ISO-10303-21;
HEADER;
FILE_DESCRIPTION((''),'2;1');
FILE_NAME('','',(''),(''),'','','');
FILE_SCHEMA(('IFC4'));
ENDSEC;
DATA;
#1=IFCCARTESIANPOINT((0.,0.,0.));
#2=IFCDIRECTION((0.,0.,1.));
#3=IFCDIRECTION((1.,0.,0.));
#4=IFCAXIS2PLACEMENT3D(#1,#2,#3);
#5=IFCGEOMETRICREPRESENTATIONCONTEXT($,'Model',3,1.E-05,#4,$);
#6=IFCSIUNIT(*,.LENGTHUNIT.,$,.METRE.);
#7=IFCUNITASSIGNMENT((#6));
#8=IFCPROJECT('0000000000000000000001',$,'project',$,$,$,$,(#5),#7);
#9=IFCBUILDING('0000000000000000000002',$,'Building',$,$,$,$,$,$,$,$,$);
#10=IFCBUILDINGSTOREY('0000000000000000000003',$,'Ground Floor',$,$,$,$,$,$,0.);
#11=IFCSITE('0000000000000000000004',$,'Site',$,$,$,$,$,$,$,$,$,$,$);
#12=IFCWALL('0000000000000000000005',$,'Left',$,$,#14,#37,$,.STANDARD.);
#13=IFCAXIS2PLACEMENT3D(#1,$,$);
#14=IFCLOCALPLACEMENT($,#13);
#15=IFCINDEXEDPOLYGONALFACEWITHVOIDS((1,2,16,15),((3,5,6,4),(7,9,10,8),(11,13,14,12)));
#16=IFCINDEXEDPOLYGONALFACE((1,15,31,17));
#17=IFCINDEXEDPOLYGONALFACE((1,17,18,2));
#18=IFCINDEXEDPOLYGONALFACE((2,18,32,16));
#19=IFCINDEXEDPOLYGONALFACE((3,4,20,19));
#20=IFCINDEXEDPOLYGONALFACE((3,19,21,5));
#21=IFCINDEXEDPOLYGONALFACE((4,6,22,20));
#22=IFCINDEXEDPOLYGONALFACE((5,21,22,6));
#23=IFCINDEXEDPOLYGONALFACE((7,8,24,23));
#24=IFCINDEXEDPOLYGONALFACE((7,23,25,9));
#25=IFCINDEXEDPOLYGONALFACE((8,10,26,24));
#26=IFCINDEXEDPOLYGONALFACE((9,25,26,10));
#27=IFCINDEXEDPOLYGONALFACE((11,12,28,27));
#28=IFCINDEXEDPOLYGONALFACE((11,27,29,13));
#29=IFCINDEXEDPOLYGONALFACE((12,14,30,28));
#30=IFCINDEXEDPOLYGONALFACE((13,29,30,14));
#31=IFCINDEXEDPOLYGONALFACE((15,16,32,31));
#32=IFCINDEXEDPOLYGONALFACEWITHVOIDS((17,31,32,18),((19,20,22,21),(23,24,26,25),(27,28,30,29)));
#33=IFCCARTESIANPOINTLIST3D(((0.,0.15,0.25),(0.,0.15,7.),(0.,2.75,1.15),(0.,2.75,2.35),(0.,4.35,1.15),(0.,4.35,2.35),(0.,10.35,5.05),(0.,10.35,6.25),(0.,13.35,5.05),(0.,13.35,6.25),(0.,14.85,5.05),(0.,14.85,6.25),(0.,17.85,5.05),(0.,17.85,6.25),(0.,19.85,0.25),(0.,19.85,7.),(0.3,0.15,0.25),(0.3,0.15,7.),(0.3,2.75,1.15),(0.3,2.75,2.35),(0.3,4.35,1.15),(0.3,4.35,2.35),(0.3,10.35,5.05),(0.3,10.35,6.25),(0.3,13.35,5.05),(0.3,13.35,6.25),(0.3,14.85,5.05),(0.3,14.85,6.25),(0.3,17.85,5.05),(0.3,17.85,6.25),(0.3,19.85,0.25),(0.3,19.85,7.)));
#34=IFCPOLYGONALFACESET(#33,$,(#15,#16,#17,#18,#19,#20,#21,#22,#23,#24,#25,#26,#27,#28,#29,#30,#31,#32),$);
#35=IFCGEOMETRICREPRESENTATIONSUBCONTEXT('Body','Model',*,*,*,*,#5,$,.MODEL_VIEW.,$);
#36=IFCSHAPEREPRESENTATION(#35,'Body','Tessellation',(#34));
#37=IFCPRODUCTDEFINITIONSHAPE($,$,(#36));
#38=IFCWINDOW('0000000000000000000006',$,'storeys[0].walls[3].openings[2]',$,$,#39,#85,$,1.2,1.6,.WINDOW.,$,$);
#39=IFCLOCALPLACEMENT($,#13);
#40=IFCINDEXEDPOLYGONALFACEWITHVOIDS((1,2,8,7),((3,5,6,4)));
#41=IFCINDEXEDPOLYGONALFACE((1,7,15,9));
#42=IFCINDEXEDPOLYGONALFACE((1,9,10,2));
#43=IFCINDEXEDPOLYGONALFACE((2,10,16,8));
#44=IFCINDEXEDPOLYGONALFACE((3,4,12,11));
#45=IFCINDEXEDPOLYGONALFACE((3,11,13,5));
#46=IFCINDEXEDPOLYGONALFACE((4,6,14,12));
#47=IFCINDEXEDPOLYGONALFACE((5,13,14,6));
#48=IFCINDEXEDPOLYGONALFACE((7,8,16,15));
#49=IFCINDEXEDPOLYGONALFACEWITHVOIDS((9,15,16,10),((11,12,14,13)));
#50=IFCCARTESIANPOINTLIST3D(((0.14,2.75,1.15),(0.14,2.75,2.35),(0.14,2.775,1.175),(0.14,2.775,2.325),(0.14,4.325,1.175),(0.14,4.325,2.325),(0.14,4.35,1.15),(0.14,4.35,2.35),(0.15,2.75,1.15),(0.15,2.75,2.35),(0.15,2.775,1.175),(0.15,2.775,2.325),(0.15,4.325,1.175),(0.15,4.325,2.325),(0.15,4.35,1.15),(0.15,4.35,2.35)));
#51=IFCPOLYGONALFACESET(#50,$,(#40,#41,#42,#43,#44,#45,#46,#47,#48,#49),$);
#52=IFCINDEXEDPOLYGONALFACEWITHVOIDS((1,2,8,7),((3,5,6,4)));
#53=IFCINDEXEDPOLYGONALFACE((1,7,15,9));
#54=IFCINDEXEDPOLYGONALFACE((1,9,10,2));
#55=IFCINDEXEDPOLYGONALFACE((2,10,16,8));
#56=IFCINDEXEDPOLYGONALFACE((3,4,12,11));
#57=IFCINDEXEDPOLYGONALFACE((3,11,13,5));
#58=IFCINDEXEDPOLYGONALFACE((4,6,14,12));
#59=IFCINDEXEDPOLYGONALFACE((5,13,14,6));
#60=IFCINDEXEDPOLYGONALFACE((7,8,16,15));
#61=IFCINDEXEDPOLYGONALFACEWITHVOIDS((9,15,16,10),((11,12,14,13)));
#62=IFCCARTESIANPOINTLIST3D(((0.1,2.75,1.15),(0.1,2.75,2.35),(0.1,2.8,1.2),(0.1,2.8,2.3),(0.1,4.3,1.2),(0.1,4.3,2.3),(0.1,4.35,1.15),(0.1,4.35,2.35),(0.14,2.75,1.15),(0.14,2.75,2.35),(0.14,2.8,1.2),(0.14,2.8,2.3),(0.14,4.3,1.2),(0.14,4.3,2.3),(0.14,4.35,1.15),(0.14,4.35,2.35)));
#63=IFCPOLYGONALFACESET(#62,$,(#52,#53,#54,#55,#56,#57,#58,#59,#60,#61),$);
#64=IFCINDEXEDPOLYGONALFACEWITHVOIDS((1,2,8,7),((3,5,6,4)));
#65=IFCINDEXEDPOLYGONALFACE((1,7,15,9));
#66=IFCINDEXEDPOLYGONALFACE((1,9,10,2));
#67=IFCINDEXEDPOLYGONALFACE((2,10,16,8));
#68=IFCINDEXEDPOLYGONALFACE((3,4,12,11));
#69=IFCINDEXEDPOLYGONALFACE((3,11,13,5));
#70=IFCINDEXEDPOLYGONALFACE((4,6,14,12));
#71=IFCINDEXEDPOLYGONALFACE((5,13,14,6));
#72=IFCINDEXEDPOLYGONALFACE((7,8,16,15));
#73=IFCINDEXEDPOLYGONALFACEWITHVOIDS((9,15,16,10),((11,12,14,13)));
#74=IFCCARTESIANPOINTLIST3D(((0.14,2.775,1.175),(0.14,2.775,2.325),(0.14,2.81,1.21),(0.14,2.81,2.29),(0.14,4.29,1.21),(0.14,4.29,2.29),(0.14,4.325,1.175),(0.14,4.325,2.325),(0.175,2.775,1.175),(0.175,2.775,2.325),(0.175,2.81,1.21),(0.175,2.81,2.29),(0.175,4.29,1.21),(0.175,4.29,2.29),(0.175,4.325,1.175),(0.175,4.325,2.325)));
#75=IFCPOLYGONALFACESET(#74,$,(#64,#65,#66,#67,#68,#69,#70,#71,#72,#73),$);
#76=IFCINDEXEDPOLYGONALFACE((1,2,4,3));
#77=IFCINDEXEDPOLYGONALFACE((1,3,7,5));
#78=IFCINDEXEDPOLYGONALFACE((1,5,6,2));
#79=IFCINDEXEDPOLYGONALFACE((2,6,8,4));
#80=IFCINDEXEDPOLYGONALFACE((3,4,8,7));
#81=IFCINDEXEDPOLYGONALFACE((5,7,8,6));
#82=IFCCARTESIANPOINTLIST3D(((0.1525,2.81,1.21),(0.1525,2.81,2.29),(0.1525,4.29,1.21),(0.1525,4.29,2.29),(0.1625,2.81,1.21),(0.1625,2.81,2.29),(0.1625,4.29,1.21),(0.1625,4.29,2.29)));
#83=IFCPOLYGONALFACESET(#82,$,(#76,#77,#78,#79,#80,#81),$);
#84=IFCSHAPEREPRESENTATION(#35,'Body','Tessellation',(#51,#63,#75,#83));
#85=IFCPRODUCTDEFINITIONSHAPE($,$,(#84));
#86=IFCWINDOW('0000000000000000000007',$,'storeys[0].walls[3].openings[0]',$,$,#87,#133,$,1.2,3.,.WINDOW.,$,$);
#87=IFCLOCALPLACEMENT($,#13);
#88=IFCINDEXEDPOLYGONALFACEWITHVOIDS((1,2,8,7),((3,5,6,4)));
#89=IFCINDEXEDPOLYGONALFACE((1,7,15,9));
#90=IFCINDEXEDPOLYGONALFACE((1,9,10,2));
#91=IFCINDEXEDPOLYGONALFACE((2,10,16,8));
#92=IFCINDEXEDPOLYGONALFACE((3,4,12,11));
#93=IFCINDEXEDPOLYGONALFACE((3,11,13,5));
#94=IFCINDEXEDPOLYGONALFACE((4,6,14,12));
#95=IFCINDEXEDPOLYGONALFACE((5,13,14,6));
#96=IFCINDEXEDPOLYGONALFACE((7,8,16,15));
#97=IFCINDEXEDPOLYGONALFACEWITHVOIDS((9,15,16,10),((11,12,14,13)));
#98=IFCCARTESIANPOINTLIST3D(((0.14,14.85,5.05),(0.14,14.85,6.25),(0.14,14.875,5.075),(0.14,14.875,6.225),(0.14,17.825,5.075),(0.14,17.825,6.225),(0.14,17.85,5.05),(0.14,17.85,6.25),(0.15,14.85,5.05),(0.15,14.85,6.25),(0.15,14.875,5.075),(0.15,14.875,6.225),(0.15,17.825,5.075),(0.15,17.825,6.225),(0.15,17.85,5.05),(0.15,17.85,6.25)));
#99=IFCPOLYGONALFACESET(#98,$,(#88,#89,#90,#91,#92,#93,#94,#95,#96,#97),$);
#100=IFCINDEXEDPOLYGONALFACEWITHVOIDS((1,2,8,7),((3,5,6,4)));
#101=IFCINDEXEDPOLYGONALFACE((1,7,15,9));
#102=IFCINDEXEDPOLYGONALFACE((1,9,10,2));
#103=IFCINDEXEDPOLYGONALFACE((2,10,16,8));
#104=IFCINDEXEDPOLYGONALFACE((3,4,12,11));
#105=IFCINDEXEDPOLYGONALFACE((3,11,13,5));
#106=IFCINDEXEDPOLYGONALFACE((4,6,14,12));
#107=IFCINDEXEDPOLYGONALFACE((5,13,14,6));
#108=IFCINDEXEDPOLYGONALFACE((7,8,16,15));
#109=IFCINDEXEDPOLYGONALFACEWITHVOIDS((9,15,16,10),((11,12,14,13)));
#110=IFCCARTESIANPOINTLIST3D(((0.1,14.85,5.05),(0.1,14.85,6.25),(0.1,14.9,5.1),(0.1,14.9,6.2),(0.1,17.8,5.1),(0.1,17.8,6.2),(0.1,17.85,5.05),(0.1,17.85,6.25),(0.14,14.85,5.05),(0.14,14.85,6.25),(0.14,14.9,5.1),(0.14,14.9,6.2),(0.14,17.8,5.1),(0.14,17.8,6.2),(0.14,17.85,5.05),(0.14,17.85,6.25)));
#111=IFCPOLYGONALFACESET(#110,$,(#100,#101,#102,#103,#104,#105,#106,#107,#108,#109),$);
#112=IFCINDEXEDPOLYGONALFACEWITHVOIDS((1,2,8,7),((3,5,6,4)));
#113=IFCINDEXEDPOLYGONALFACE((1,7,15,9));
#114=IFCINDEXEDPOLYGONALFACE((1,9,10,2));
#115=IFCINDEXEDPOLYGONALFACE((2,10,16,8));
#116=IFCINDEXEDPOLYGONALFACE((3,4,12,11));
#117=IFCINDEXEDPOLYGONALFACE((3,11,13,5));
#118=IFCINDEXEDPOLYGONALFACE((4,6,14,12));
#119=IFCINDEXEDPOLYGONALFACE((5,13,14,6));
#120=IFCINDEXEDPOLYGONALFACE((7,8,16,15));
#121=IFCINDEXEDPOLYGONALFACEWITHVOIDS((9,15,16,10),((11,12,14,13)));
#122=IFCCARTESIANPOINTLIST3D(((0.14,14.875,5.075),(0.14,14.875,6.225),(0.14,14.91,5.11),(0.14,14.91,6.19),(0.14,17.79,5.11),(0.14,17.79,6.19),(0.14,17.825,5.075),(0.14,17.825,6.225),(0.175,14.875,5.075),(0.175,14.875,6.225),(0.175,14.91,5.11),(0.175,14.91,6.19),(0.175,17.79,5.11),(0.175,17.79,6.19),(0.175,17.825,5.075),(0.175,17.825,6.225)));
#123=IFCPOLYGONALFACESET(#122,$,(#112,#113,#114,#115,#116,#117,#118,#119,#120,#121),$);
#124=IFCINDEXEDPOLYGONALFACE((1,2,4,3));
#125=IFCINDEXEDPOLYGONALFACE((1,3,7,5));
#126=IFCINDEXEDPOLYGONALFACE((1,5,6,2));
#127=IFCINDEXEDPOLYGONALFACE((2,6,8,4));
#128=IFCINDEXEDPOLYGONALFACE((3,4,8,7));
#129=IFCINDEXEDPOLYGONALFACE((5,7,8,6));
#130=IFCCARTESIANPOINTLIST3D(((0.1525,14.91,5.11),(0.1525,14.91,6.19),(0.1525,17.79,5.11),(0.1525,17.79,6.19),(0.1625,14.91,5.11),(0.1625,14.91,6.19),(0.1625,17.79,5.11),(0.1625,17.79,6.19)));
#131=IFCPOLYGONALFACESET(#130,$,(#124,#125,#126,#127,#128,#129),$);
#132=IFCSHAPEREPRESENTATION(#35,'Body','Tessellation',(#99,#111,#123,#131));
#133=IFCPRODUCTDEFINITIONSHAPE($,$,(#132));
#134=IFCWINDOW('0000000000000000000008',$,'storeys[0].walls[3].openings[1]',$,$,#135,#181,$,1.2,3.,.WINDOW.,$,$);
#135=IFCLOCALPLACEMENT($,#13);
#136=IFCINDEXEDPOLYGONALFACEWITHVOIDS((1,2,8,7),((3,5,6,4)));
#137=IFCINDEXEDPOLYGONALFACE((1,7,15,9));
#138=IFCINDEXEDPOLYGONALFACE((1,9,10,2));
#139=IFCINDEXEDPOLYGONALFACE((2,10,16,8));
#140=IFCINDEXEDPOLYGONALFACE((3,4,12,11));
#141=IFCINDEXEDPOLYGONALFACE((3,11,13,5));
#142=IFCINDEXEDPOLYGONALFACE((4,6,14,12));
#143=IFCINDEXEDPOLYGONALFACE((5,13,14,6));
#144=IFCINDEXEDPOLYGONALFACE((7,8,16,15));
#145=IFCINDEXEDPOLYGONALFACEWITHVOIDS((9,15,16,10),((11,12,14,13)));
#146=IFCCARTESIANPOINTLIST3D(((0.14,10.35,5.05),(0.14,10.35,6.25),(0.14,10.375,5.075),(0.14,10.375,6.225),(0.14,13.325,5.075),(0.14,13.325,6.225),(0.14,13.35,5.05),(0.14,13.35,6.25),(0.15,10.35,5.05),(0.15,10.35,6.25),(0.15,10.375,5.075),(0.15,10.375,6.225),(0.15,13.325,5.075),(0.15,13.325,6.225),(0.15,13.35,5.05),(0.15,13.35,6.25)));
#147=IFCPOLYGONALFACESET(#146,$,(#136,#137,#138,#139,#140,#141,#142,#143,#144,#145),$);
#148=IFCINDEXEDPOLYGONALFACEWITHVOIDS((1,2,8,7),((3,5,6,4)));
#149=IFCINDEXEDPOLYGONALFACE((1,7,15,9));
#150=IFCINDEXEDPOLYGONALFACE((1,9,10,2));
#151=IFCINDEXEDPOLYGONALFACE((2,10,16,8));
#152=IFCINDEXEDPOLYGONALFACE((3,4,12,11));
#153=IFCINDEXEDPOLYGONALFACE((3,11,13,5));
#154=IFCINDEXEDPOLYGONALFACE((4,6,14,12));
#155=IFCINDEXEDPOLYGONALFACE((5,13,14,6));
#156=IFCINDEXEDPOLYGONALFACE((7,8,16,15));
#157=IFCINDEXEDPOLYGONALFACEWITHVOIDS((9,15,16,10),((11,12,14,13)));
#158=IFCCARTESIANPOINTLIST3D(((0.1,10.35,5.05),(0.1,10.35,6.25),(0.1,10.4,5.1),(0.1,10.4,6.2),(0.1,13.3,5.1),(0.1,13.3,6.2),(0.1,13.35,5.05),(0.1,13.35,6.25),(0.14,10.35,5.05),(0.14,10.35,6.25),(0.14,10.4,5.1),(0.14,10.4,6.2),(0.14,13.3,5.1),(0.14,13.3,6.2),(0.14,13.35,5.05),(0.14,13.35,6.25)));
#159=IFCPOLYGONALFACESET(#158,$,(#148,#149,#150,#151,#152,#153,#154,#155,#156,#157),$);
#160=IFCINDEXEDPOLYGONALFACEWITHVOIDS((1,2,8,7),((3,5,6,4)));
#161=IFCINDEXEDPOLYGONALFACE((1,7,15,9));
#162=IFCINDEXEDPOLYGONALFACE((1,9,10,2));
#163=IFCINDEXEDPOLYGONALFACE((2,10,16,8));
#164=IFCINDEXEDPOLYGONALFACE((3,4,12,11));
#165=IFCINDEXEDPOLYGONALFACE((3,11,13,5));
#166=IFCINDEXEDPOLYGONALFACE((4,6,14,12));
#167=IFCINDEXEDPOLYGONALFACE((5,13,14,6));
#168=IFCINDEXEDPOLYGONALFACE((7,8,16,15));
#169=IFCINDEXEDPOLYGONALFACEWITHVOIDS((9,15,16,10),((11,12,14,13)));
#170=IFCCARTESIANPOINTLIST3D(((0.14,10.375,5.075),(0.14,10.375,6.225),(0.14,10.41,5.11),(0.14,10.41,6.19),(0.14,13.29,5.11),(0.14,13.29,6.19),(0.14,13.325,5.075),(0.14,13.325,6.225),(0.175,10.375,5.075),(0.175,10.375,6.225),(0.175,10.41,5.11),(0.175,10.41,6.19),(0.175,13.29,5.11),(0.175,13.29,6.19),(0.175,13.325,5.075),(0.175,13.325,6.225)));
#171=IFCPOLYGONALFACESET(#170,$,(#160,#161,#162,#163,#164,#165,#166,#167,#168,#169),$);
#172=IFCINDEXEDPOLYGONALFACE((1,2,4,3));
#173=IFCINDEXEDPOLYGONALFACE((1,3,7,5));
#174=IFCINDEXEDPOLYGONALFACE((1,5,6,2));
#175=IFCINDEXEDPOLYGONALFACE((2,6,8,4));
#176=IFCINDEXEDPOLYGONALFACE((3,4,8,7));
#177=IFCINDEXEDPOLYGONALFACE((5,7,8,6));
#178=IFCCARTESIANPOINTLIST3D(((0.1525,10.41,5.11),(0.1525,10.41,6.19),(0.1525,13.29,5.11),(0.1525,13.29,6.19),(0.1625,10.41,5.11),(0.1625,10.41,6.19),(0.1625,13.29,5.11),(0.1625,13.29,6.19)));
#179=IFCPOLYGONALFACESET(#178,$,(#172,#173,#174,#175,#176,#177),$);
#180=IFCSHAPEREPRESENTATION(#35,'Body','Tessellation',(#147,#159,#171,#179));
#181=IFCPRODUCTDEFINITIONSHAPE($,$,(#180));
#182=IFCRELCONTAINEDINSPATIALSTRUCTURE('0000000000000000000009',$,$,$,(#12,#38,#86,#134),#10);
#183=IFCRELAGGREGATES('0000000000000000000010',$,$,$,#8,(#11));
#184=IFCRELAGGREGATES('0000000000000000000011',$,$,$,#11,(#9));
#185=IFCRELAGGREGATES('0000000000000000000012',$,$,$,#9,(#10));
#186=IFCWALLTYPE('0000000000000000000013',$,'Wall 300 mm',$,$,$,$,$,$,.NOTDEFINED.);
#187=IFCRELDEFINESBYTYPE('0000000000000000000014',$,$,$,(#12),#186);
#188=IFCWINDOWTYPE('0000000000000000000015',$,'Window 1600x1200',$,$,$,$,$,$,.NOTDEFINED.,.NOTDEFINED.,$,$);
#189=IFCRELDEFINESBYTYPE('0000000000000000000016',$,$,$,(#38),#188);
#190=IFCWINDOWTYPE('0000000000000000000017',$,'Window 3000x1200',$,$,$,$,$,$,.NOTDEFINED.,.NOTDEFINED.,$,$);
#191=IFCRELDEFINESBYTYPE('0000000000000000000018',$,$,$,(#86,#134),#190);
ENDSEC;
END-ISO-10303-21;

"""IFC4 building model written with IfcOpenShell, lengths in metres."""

from ifc_helpers import new_model, si_unit, frame, origin_with_axes, place, context, subcontext, project, spatial, line, indexed_curve, outline, extrude, type_object, element, fill, save


model = new_model("IFC4")

# Units and contexts
model_context = context("Model", 3, precision=1e-05, world=origin_with_axes())
body_context = subcontext(model_context, "Body", "Model", "MODEL_VIEW")
ifc_project = project(units=[si_unit("LENGTHUNIT", "METRE")], contexts=[model_context])

# Site, building, storey
site = spatial("IfcSite", under=ifc_project, Name="Site")
building = spatial("IfcBuilding", under=site, Name="Building")
storey = spatial("IfcBuildingStorey", under=building, Name="Ground Floor", Elevation=0.0)

# Shared definitions
wall_type_1 = type_object("IfcWallType", Name="Wall 300 mm", PredefinedType="NOTDEFINED")
window_type_1 = type_object("IfcWindowType", Name="Window 1600x1200", PartitioningType="NOTDEFINED", PredefinedType="NOTDEFINED")

# Wall, openings, windows
wall_1_placement = place(None, frame((0.15, 19.85, 0.25), z_axis=(0.0, 0.0, 1.0), x_axis=(0.0, -1.0, 0.0)))
wall_1 = element("IfcWall", 1, at=wall_1_placement, inside=storey, type_object=wall_type_1, Name="Left", PredefinedType="STANDARD", context=body_context, shape_type="SweptSolid", body=[
    extrude(outline(indexed_curve([(0.0, 0.0), (0.0, 0.3), (19.7, 0.3), (19.7, 0.0), (0.0, 0.0)], self_intersect=False)), frame((0.0, -0.15, 0.0), z_axis=(0.0, 0.0, 1.0), x_axis=(1.0, 0.0, 0.0)), (0.0, 0.0, 1.0), 6.75),
])
opening_1_placement = place(wall_1_placement, frame((2.0, -0.16, 4.8), z_axis=(0.0, 0.0, 1.0), x_axis=(1.0, 0.0, 0.0)))
opening_1 = element("IfcOpeningElement", 2, at=opening_1_placement, cuts=wall_1, context=body_context, shape_type="SweptSolid", body=[
    extrude(outline(indexed_curve([(0.0, 0.0), (0.0, 0.32), (3.0, 0.32), (3.0, 0.0), (0.0, 0.0)], self_intersect=False)), origin_with_axes(), (0.0, 0.0, 1.0), 1.2),
])
opening_2_placement = place(wall_1_placement, frame((6.5, -0.16, 4.8), z_axis=(0.0, 0.0, 1.0), x_axis=(1.0, 0.0, 0.0)))
opening_2 = element("IfcOpeningElement", 3, at=opening_2_placement, cuts=wall_1, context=body_context, shape_type="SweptSolid", body=[
    extrude(outline(indexed_curve([(0.0, 0.0), (0.0, 0.32), (3.0, 0.32), (3.0, 0.0), (0.0, 0.0)], self_intersect=False)), origin_with_axes(), (0.0, 0.0, 1.0), 1.2),
])
opening_3_placement = place(wall_1_placement, frame((15.5, -0.16, 0.9), z_axis=(0.0, 0.0, 1.0), x_axis=(1.0, 0.0, 0.0)))
opening_3 = element("IfcOpeningElement", 4, at=opening_3_placement, cuts=wall_1, context=body_context, shape_type="SweptSolid", body=[
    extrude(outline(indexed_curve([(0.0, 0.0), (0.0, 0.32), (1.6, 0.32), (1.6, 0.0), (0.0, 0.0)], self_intersect=False)), origin_with_axes(), (0.0, 0.0, 1.0), 1.2),
])
window_1_placement = place(None, frame((0.05, 4.35, 1.15), z_axis=(0.0, 0.0, 1.0), x_axis=(0.0, -1.0, 0.0)))
window_1 = element("IfcWindow", 5, at=window_1_placement, inside=storey, type_object=window_type_1, Name="storeys[0].walls[3].openings[2]", OverallHeight=1.2, OverallWidth=1.6, PredefinedType="WINDOW", context=body_context, shape_type="SweptSolid", body=[
    extrude(outline(indexed_curve([(0.0, 0.0), (1.6, 0.0), (1.6, 1.2), (0.0, 1.2)], segments=[line(1, 2, 3, 4, 1)]), holes=[indexed_curve([(0.025, 0.025), (1.575, 0.025), (1.575, 1.175), (0.025, 1.175)], segments=[line(1, 2, 3, 4, 1)])]), frame((0.0, 0.09, 0.0), z_axis=(0.0, -1.0, 0.0), x_axis=(1.0, 0.0, 0.0)), (0.0, 0.0, -1.0), 0.01),
    extrude(outline(indexed_curve([(0.0, 0.0), (1.6, 0.0), (1.6, 1.2), (0.0, 1.2)], segments=[line(1, 2, 3, 4, 1)]), holes=[indexed_curve([(0.05, 0.05), (1.55, 0.05), (1.55, 1.15), (0.05, 1.15)], segments=[line(1, 2, 3, 4, 1)])]), frame((0.0, 0.05, 0.0), z_axis=(0.0, -1.0, 0.0), x_axis=(1.0, 0.0, 0.0)), (0.0, 0.0, -1.0), 0.04),
    extrude(outline(indexed_curve([(0.0, 0.0), (1.55, 0.0), (1.55, 1.15), (0.0, 1.15)], segments=[line(1, 2, 3, 4, 1)]), holes=[indexed_curve([(0.035, 0.035), (1.515, 0.035), (1.515, 1.115), (0.035, 1.115)], segments=[line(1, 2, 3, 4, 1)])]), frame((0.025, 0.09, 0.025), z_axis=(0.0, -1.0, 0.0), x_axis=(1.0, 0.0, 0.0)), (0.0, 0.0, -1.0), 0.035),
    extrude(outline(indexed_curve([(0.035, 0.035), (1.515, 0.035), (1.515, 1.115), (0.035, 1.115)], segments=[line(1, 2, 3, 4, 1)])), frame((0.025, 0.1025, 0.025), z_axis=(0.0, -1.0, 0.0), x_axis=(1.0, 0.0, 0.0)), (0.0, 0.0, -1.0), 0.01),
])
fill(opening_3, window_1)
window_type_2 = type_object("IfcWindowType", Name="Window 3000x1200", PartitioningType="NOTDEFINED", PredefinedType="NOTDEFINED")
window_2_placement = place(None, frame((0.05, 17.85, 5.05), z_axis=(0.0, 0.0, 1.0), x_axis=(0.0, -1.0, 0.0)))
window_2 = element("IfcWindow", 6, at=window_2_placement, inside=storey, type_object=window_type_2, Name="storeys[0].walls[3].openings[0]", OverallHeight=1.2, OverallWidth=3.0, PredefinedType="WINDOW", context=body_context, shape_type="SweptSolid", body=[
    extrude(outline(indexed_curve([(0.0, 0.0), (3.0, 0.0), (3.0, 1.2), (0.0, 1.2)], segments=[line(1, 2, 3, 4, 1)]), holes=[indexed_curve([(0.025, 0.025), (2.975, 0.025), (2.975, 1.175), (0.025, 1.175)], segments=[line(1, 2, 3, 4, 1)])]), frame((0.0, 0.09, 0.0), z_axis=(0.0, -1.0, 0.0), x_axis=(1.0, 0.0, 0.0)), (0.0, 0.0, -1.0), 0.01),
    extrude(outline(indexed_curve([(0.0, 0.0), (3.0, 0.0), (3.0, 1.2), (0.0, 1.2)], segments=[line(1, 2, 3, 4, 1)]), holes=[indexed_curve([(0.05, 0.05), (2.95, 0.05), (2.95, 1.15), (0.05, 1.15)], segments=[line(1, 2, 3, 4, 1)])]), frame((0.0, 0.05, 0.0), z_axis=(0.0, -1.0, 0.0), x_axis=(1.0, 0.0, 0.0)), (0.0, 0.0, -1.0), 0.04),
    extrude(outline(indexed_curve([(0.0, 0.0), (2.95, 0.0), (2.95, 1.15), (0.0, 1.15)], segments=[line(1, 2, 3, 4, 1)]), holes=[indexed_curve([(0.035, 0.035), (2.915, 0.035), (2.915, 1.115), (0.035, 1.115)], segments=[line(1, 2, 3, 4, 1)])]), frame((0.025, 0.09, 0.025), z_axis=(0.0, -1.0, 0.0), x_axis=(1.0, 0.0, 0.0)), (0.0, 0.0, -1.0), 0.035),
    extrude(outline(indexed_curve([(0.035, 0.035), (2.915, 0.035), (2.915, 1.115), (0.035, 1.115)], segments=[line(1, 2, 3, 4, 1)])), frame((0.025, 0.1025, 0.025), z_axis=(0.0, -1.0, 0.0), x_axis=(1.0, 0.0, 0.0)), (0.0, 0.0, -1.0), 0.01),
])
fill(opening_1, window_2)
window_3_placement = place(None, frame((0.05, 13.35, 5.05), z_axis=(0.0, 0.0, 1.0), x_axis=(0.0, -1.0, 0.0)))
window_3 = element("IfcWindow", 7, at=window_3_placement, inside=storey, type_object=window_type_2, Name="storeys[0].walls[3].openings[1]", OverallHeight=1.2, OverallWidth=3.0, PredefinedType="WINDOW", context=body_context, shape_type="SweptSolid", body=[
    extrude(outline(indexed_curve([(0.0, 0.0), (3.0, 0.0), (3.0, 1.2), (0.0, 1.2)], segments=[line(1, 2, 3, 4, 1)]), holes=[indexed_curve([(0.025, 0.025), (2.975, 0.025), (2.975, 1.175), (0.025, 1.175)], segments=[line(1, 2, 3, 4, 1)])]), frame((0.0, 0.09, 0.0), z_axis=(0.0, -1.0, 0.0), x_axis=(1.0, 0.0, 0.0)), (0.0, 0.0, -1.0), 0.01),
    extrude(outline(indexed_curve([(0.0, 0.0), (3.0, 0.0), (3.0, 1.2), (0.0, 1.2)], segments=[line(1, 2, 3, 4, 1)]), holes=[indexed_curve([(0.05, 0.05), (2.95, 0.05), (2.95, 1.15), (0.05, 1.15)], segments=[line(1, 2, 3, 4, 1)])]), frame((0.0, 0.05, 0.0), z_axis=(0.0, -1.0, 0.0), x_axis=(1.0, 0.0, 0.0)), (0.0, 0.0, -1.0), 0.04),
    extrude(outline(indexed_curve([(0.0, 0.0), (2.95, 0.0), (2.95, 1.15), (0.0, 1.15)], segments=[line(1, 2, 3, 4, 1)]), holes=[indexed_curve([(0.035, 0.035), (2.915, 0.035), (2.915, 1.115), (0.035, 1.115)], segments=[line(1, 2, 3, 4, 1)])]), frame((0.025, 0.09, 0.025), z_axis=(0.0, -1.0, 0.0), x_axis=(1.0, 0.0, 0.0)), (0.0, 0.0, -1.0), 0.035),
    extrude(outline(indexed_curve([(0.035, 0.035), (2.915, 0.035), (2.915, 1.115), (0.035, 1.115)], segments=[line(1, 2, 3, 4, 1)])), frame((0.025, 0.1025, 0.025), z_axis=(0.0, -1.0, 0.0), x_axis=(1.0, 0.0, 0.0)), (0.0, 0.0, -1.0), 0.01),
])
fill(opening_2, window_3)

save(model, "model.ifc")
